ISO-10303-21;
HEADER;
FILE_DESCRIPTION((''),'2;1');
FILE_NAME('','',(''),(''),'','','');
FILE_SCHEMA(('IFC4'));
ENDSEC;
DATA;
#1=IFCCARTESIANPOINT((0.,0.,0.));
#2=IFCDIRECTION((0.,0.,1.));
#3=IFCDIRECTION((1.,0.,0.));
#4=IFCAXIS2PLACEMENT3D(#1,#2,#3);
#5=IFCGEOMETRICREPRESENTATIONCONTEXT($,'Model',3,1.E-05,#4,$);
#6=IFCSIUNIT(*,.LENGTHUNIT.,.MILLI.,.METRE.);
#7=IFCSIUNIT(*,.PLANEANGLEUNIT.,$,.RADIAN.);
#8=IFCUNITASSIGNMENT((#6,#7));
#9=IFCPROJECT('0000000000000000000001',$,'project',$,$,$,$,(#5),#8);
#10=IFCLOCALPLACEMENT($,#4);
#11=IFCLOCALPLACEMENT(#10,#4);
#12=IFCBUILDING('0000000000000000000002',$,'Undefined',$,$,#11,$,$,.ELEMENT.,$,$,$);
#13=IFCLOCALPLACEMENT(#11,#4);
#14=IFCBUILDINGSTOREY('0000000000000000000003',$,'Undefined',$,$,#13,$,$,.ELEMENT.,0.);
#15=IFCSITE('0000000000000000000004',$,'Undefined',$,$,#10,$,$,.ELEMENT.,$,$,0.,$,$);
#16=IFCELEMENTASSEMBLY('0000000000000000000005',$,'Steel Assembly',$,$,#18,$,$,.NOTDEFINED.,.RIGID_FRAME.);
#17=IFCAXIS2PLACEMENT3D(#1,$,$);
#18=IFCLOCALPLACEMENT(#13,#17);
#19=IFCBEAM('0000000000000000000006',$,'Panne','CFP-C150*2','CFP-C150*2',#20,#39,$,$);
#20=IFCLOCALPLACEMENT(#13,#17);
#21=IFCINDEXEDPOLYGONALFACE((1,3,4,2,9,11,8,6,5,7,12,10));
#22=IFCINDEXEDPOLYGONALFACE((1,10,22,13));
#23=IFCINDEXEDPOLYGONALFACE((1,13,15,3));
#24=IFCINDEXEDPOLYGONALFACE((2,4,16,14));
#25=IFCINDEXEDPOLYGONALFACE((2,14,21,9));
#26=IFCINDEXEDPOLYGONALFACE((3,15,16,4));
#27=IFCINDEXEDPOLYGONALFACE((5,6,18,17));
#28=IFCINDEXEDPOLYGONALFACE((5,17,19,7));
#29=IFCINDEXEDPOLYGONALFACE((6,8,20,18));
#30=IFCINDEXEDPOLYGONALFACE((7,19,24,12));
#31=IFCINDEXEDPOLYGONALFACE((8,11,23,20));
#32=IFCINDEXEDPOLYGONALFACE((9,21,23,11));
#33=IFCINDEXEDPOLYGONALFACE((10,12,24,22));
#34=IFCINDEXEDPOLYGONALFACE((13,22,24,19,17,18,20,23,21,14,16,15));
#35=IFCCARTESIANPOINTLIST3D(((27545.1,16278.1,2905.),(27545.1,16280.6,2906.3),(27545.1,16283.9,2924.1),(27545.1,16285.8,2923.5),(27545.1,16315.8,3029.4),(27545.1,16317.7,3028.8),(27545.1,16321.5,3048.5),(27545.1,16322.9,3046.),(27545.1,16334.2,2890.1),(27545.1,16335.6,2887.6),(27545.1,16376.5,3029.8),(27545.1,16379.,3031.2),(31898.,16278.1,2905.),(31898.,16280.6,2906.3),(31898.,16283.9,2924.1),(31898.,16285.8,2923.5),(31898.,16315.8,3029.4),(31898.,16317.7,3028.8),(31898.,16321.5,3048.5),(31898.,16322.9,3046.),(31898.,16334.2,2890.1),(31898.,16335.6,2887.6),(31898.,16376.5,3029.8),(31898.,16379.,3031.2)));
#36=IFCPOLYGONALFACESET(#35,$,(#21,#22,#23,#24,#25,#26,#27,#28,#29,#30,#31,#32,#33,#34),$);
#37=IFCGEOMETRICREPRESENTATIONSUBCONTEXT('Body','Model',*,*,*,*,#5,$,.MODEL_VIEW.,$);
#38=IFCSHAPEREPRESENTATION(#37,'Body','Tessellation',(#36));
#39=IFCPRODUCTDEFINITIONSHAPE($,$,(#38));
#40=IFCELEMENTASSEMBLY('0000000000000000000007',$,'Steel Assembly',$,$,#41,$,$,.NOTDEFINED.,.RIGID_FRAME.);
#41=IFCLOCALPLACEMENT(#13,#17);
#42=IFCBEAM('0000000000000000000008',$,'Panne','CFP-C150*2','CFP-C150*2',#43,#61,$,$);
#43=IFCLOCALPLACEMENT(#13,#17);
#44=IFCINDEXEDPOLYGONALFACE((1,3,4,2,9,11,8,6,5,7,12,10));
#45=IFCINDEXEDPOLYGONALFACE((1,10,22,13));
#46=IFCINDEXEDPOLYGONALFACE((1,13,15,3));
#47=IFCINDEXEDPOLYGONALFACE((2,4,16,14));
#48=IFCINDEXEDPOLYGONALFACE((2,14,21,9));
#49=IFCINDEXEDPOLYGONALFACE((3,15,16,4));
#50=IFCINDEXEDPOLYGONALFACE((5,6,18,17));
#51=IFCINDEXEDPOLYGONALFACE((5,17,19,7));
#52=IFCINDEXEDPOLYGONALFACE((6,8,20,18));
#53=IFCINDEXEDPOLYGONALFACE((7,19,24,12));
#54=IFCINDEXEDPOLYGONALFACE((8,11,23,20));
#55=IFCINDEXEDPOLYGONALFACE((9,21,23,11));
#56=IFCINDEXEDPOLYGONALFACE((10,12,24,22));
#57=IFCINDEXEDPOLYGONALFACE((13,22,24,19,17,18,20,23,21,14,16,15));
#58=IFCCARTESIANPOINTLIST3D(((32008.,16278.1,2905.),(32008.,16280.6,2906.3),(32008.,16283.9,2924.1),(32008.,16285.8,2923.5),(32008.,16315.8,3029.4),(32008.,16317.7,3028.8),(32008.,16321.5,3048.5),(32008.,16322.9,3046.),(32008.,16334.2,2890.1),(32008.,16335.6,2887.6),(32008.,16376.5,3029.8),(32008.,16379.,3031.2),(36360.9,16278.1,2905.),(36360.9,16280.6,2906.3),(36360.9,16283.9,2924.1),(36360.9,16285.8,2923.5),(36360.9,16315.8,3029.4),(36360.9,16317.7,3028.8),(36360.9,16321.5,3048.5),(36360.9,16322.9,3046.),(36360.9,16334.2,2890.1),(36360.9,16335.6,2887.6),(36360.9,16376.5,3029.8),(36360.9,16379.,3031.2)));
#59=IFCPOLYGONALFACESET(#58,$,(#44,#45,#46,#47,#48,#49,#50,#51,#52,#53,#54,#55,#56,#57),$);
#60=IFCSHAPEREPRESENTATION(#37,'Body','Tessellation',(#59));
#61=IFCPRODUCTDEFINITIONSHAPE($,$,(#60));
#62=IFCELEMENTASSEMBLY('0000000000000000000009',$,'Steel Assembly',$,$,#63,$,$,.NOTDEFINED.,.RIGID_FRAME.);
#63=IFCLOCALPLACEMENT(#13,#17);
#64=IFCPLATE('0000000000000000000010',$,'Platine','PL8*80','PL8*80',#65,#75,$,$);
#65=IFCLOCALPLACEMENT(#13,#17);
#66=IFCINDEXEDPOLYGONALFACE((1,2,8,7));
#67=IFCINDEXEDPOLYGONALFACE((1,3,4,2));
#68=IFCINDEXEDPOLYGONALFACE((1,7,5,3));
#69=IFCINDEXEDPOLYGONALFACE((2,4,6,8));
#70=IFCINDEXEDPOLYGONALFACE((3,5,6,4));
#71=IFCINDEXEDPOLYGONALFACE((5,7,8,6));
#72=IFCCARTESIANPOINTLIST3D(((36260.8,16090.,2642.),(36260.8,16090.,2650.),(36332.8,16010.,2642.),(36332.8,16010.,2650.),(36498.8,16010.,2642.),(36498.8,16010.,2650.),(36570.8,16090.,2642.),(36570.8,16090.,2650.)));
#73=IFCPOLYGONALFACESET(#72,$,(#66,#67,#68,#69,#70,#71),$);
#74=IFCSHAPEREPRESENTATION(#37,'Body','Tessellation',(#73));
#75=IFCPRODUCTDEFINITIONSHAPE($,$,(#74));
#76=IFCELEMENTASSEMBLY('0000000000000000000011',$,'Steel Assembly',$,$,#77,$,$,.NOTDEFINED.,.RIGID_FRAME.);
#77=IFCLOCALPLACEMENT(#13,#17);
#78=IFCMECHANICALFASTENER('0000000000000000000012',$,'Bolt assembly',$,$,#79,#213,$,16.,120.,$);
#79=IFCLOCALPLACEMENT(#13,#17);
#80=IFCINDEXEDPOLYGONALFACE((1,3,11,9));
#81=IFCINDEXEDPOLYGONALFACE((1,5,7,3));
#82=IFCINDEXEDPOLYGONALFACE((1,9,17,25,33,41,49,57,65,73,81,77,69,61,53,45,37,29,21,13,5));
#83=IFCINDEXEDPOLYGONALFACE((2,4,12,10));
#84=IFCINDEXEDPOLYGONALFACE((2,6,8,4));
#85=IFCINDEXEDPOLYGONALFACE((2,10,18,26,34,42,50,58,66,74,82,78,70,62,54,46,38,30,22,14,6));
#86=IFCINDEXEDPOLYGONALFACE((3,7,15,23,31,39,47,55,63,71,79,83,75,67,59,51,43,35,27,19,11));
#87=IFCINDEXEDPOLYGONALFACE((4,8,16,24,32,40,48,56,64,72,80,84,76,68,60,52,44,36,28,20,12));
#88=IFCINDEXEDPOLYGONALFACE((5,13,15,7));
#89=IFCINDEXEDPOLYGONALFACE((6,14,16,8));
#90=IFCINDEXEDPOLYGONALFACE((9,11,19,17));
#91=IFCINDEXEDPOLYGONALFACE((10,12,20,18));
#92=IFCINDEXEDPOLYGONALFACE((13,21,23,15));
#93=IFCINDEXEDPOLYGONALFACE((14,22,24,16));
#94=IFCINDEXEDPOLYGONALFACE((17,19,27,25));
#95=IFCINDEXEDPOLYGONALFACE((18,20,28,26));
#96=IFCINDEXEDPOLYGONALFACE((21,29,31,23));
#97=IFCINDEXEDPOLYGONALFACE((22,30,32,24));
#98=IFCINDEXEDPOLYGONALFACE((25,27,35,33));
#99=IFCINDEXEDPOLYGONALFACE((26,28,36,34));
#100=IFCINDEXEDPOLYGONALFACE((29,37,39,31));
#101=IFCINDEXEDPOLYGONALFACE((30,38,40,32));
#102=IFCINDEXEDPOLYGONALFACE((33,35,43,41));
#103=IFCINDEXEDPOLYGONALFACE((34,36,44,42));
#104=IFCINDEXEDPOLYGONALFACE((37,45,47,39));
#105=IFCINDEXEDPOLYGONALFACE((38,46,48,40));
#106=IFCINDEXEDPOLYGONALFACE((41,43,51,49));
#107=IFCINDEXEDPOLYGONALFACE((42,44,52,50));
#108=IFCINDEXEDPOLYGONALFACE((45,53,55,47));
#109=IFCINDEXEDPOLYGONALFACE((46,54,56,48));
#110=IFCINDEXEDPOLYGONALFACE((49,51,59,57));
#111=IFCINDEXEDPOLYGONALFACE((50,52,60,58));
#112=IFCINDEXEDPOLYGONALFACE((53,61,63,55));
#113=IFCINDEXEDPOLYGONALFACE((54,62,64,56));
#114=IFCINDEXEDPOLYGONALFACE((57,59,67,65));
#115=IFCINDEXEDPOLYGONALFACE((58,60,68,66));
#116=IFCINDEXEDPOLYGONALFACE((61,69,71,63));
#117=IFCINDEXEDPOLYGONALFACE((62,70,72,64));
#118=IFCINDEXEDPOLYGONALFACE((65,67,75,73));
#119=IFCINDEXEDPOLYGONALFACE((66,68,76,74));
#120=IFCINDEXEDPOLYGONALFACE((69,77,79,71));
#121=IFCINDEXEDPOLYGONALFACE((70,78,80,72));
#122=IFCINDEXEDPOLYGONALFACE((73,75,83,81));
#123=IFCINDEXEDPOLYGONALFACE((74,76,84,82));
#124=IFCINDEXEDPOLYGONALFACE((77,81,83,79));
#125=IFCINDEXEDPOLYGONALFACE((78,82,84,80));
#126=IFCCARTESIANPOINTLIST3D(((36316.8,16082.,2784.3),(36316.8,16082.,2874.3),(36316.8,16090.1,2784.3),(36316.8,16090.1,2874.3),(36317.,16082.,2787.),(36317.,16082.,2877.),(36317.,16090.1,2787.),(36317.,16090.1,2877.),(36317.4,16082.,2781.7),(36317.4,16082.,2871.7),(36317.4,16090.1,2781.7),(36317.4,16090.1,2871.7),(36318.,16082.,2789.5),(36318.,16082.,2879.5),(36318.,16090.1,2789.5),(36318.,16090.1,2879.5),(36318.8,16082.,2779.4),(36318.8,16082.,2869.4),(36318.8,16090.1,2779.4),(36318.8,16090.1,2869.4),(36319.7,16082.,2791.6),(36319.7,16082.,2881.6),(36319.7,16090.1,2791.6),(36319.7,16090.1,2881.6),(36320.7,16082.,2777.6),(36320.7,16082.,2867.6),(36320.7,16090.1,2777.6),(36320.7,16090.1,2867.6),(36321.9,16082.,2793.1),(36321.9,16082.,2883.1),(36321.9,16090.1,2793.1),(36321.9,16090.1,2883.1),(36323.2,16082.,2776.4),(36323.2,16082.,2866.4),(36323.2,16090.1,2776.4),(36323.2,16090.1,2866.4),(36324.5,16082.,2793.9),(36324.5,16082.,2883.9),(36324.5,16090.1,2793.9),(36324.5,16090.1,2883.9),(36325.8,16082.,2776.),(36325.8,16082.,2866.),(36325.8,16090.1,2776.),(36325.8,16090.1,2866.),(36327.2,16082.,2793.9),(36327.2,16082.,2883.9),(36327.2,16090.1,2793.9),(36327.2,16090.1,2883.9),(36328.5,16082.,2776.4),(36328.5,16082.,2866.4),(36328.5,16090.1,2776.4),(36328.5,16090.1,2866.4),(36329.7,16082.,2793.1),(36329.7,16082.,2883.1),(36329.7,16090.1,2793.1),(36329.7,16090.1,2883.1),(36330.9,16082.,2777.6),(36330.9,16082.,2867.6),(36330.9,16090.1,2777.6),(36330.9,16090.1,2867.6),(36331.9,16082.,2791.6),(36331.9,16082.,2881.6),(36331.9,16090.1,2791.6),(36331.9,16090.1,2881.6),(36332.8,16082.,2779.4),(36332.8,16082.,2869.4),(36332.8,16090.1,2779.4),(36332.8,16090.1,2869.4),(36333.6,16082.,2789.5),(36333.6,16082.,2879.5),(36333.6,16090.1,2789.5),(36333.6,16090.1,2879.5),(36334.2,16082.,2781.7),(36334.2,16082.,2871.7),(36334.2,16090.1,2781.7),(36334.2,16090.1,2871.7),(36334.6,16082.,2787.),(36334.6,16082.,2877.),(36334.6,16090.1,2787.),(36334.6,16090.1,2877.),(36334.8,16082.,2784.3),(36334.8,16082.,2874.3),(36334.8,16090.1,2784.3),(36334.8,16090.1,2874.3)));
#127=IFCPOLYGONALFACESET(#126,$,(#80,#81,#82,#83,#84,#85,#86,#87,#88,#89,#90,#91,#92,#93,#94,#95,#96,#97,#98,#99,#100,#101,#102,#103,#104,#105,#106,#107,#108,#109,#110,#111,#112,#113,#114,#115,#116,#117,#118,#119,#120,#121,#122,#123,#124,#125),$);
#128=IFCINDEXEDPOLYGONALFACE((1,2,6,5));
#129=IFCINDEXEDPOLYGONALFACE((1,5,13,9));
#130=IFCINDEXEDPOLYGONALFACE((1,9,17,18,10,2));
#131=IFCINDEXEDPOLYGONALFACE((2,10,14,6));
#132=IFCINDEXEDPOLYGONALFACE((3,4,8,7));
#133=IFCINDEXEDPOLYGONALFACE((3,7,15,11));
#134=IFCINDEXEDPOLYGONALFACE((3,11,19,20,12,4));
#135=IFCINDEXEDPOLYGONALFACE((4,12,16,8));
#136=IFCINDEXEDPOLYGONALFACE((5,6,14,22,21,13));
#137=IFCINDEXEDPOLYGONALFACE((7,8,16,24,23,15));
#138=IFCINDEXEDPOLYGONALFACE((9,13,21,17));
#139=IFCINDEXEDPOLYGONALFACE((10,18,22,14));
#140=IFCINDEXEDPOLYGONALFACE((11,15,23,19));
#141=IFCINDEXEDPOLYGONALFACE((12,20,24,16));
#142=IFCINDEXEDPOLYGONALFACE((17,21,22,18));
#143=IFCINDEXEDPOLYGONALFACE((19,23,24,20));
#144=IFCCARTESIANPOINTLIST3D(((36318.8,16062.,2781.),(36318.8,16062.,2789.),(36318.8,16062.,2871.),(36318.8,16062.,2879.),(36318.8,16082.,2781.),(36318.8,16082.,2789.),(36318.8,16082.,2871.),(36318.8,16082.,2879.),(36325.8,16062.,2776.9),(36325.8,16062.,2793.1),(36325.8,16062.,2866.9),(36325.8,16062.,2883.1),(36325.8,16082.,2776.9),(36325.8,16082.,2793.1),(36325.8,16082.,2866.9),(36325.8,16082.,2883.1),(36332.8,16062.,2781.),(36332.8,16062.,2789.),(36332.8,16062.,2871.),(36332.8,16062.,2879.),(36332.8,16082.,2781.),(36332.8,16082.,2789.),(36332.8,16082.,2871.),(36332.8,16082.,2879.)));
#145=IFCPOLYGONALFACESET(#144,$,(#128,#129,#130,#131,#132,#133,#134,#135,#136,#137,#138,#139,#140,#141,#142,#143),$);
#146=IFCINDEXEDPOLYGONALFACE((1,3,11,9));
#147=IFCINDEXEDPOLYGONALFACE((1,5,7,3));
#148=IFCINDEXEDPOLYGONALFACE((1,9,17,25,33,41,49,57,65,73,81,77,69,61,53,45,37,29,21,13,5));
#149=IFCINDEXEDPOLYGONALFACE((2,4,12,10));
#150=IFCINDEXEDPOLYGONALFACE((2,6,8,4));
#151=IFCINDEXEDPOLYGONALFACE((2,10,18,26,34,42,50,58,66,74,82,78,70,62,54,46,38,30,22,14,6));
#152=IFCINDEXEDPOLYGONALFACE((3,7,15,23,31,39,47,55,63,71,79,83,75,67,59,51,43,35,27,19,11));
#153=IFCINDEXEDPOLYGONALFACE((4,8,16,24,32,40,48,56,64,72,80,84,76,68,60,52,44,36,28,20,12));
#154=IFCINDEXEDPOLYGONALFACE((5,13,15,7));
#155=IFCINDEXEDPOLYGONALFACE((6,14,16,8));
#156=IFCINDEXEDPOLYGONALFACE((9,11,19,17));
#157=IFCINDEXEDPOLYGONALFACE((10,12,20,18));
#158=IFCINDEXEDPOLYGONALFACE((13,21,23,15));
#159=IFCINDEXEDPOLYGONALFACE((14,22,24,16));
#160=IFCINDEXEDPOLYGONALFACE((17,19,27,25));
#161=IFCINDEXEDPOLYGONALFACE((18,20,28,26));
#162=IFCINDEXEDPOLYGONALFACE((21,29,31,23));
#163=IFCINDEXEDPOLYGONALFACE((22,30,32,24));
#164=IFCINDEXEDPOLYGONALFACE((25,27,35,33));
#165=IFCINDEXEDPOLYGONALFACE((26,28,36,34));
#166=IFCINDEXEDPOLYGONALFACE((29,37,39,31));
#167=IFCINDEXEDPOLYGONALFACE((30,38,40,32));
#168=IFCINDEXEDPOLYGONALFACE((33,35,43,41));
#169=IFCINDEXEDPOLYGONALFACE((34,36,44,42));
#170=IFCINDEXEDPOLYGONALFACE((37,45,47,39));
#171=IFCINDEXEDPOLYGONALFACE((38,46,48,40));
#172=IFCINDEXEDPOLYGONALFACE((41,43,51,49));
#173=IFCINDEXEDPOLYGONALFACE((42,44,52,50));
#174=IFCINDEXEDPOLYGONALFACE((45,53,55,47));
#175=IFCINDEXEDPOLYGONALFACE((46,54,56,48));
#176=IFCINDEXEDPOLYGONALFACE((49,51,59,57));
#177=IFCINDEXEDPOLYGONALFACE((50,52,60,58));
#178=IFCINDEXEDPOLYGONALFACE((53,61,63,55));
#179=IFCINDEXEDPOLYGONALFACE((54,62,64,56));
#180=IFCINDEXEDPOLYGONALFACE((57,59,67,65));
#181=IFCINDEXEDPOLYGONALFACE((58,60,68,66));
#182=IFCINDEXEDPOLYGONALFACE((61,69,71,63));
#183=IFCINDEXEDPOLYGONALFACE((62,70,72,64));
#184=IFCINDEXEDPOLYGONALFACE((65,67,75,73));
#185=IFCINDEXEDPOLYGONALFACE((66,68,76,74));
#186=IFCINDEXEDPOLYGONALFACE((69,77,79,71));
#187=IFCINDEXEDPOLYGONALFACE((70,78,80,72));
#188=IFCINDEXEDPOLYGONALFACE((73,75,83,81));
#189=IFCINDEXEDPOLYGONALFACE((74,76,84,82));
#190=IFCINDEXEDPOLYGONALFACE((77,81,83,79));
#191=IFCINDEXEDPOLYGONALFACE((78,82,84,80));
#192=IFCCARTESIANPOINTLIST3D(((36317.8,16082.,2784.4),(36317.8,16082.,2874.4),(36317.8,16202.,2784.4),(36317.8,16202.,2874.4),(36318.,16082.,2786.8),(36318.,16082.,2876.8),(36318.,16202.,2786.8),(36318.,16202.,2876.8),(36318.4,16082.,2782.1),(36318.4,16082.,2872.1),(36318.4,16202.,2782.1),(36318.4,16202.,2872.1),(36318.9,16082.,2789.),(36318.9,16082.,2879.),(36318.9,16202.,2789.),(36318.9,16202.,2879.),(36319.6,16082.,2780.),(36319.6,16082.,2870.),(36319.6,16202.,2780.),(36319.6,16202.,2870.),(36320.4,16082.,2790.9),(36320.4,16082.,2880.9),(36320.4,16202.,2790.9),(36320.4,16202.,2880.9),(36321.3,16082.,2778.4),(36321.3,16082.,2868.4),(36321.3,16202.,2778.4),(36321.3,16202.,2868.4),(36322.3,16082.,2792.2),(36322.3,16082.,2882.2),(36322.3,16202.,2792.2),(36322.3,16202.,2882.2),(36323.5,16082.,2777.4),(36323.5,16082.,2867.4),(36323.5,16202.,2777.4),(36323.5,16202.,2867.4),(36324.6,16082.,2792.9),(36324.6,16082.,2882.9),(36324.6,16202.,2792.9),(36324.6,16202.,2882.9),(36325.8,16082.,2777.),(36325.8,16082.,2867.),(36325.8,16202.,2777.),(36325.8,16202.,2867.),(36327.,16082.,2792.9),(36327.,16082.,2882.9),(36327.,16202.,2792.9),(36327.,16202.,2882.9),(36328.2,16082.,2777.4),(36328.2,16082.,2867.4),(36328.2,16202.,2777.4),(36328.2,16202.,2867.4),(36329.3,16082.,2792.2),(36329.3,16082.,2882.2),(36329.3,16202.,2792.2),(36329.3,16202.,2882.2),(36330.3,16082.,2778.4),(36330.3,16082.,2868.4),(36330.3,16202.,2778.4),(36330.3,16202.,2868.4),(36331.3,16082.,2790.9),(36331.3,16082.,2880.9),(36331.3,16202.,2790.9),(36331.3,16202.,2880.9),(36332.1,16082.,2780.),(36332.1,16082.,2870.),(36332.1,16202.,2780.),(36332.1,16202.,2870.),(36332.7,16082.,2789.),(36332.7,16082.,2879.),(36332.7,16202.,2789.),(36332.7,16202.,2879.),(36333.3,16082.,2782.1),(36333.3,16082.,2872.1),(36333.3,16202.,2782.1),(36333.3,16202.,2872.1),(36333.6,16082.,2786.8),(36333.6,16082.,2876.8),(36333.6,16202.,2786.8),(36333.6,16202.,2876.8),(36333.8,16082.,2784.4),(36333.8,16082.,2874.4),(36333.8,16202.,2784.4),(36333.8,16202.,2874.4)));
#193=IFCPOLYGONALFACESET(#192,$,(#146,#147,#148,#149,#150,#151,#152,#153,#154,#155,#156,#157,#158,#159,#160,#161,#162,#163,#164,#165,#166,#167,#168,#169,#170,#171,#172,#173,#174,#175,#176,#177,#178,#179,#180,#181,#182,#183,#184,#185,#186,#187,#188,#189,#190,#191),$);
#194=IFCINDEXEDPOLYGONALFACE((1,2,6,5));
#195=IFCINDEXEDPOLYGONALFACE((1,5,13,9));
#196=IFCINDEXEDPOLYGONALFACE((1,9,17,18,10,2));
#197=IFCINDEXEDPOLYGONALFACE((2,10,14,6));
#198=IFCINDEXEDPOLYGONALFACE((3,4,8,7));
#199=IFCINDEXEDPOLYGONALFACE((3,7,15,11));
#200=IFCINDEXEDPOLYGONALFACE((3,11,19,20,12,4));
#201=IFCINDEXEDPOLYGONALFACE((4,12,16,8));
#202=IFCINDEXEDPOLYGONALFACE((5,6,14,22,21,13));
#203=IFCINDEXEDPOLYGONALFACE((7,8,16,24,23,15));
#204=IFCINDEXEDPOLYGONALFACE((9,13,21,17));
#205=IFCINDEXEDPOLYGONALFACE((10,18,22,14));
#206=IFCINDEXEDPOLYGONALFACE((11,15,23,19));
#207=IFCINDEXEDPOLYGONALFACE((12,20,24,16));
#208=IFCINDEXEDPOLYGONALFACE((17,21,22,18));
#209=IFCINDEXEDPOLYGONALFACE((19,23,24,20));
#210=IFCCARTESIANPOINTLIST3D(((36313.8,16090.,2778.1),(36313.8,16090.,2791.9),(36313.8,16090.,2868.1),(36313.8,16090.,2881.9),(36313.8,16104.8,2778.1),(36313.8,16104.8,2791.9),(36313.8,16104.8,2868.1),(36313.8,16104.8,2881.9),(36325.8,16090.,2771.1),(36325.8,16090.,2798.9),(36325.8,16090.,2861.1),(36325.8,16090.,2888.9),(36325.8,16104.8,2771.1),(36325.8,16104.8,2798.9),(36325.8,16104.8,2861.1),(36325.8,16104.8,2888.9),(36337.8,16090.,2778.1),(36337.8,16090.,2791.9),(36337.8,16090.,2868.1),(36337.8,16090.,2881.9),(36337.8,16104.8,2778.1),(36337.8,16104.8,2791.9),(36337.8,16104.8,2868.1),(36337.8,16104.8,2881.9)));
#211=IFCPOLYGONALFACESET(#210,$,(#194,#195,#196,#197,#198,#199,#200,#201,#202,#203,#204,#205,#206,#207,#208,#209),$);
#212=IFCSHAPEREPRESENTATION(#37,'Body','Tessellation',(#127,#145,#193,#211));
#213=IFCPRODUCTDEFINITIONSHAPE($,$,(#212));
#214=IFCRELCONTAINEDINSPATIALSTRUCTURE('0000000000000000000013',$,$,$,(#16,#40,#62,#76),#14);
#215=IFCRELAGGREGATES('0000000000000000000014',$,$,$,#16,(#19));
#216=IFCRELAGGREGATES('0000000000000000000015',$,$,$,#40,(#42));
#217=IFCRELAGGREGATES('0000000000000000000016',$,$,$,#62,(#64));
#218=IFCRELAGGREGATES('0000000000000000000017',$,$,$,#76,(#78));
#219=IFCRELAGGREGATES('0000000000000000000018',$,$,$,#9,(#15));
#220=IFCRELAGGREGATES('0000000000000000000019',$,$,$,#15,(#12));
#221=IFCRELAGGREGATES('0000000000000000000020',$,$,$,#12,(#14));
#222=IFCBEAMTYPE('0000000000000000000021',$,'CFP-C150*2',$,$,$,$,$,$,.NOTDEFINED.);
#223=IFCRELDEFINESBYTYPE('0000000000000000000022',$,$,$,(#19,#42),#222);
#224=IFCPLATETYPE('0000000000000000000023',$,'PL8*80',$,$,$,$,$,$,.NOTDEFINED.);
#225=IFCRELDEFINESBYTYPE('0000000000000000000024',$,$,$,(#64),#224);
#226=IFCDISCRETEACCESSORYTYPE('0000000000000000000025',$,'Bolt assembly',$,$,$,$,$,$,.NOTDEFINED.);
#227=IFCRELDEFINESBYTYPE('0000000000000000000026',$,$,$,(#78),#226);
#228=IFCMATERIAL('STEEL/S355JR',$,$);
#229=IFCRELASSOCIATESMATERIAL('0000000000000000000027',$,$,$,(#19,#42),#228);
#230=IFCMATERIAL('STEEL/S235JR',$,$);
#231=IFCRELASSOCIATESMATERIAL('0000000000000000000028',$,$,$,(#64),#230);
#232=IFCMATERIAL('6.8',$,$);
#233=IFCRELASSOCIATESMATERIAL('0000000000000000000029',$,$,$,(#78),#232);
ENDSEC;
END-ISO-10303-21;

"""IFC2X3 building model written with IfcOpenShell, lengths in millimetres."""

from ifc_helpers import new_model, si_unit, frame, origin_with_axes, origin_2d_with_axis, place, context, subcontext, project, spatial, polyline, circle, c_section, outline, extrude, source, transform, mapped, material, type_object, element, aggregate, save


model = new_model("IFC2X3")

# Units and contexts
model_context = context("Model", 3, precision=1e-05, world=origin_with_axes())
body_context = subcontext(model_context, "Body", "Model", "MODEL_VIEW")
ifc_project = project(units=[si_unit("LENGTHUNIT", "METRE", prefix="MILLI"), si_unit("PLANEANGLEUNIT", "RADIAN")], contexts=[model_context])

# Site, building, storey
site_placement = place(None, origin_with_axes())
site = spatial("IfcSite", under=ifc_project, at=site_placement, Name="Undefined", CompositionType="ELEMENT", RefElevation=0.0)
building_placement = place(site_placement, origin_with_axes())
building = spatial("IfcBuilding", under=site, at=building_placement, Name="Undefined", CompositionType="ELEMENT")
storey_placement = place(building_placement, origin_with_axes())
storey = spatial("IfcBuildingStorey", under=building, at=storey_placement, Name="Undefined", CompositionType="ELEMENT", Elevation=0.0)

# Element assemblies, beams
assembly_1_placement = place(storey_placement, origin_with_axes())
assembly_1 = element("IfcElementAssembly", 1, at=assembly_1_placement, inside=storey, Name="Steel Assembly", AssemblyPlace="NOTDEFINED", PredefinedType="RIGID_FRAME")
ifc_material_1 = material(Name="STEEL/S355JR")
beam_type = type_object("IfcBeamType", Name="CFP-C150*2", PredefinedType="NOTDEFINED")
beam_1_placement = place(assembly_1_placement, frame((31953.0, 16328.6, 2968.1), z_axis=(0.0, -0.289497, -0.957179), x_axis=(-1.0, 0.0, 0.0)))
beam_1 = element("IfcBeam", 2, at=beam_1_placement, type_object=beam_type, material=ifc_material_1, Name="Panne", Description="CFP-C150*2", ObjectType="CFP-C150*2", context=body_context, shape_type="SweptSolid", body=[
    extrude(c_section(Depth=150.0, Width=60.0, WallThickness=2.0, Girth=20.0, at=origin_2d_with_axis()), frame((4407.9, 0.0, 0.0), z_axis=(-1.0, 0.0, 0.0), x_axis=(0.0, -1.0, 0.0)), (0.0, 0.0, 1.0), 4352.9),
])
aggregate(assembly_1, [beam_1])
assembly_2_placement = place(storey_placement, origin_with_axes())
assembly_2 = element("IfcElementAssembly", 3, at=assembly_2_placement, inside=storey, Name="Steel Assembly", AssemblyPlace="NOTDEFINED", PredefinedType="RIGID_FRAME")
beam_2_placement = place(assembly_2_placement, frame((36415.8, 16328.6, 2968.1), z_axis=(0.0, -0.289497, -0.957179), x_axis=(-1.0, 0.0, 0.0)))
beam_2 = element("IfcBeam", 4, at=beam_2_placement, type_object=beam_type, material=ifc_material_1, Name="Panne", Description="CFP-C150*2", ObjectType="CFP-C150*2", context=body_context, shape_type="SweptSolid", body=[
    extrude(c_section(Depth=150.0, Width=60.0, WallThickness=2.0, Girth=20.0, at=origin_2d_with_axis()), frame((4407.9, 0.0, 0.0), z_axis=(-1.0, 0.0, 0.0), x_axis=(0.0, -1.0, 0.0)), (0.0, 0.0, 1.0), 4352.9),
])

# Element assembly, plate
assembly_3_placement = place(storey_placement, origin_with_axes())
assembly_3 = element("IfcElementAssembly", 5, at=assembly_3_placement, inside=storey, Name="Steel Assembly", AssemblyPlace="NOTDEFINED", PredefinedType="RIGID_FRAME")
ifc_material_2 = material(Name="STEEL/S235JR")
plate_type = type_object("IfcPlateType", Name="PL8*80", PredefinedType="NOTDEFINED")
plate_placement = place(assembly_3_placement, frame((36260.8, 16090.0, 2646.0), z_axis=(0.0, 0.0, 1.0), x_axis=(0.668965, -0.743294, 0.0)))
plate = element("IfcPlate", 6, at=plate_placement, type_object=plate_type, material=ifc_material_2, Name="Platine", Description="PL8*80", ObjectType="PL8*80", context=body_context, shape_type="SweptSolid", body=[
    extrude(outline(polyline([(0.0, 0.0), (107.6, 0.0), (218.7, 123.4), (207.4, 230.4), (0.0, 0.0)])), frame((0.0, 0.0, -4.0), z_axis=(0.0, 0.0, 1.0), x_axis=(1.0, 0.0, 0.0)), (0.0, 0.0, 1.0), 8.0),
])

# Element assembly, mechanical fastener
assembly_4_placement = place(storey_placement, origin_with_axes())
assembly_4 = element("IfcElementAssembly", 7, at=assembly_4_placement, inside=storey, Name="Steel Assembly", AssemblyPlace="NOTDEFINED", PredefinedType="RIGID_FRAME")
ifc_material_3 = material(Name="6.8")
discrete_accessory_type_1 = type_object("IfcDiscreteAccessoryType", Name="Bolt assembly")
shared_shape_1 = source(origin_with_axes(), body_context, "Body", "SweptSolid", [
    extrude(circle(Radius=9.0, at=origin_2d_with_axis()), frame((0.0, -8.0, 0.0), z_axis=(0.0, 1.0, 0.0), x_axis=(1.0, 0.0, 0.0)), (0.0, 0.0, 1.0), 8.1),
    extrude(outline(polyline([(8.1, 0.0), (4.0, 7.0), (-4.0, 7.0), (-8.1, 0.0), (-4.0, -7.0), (4.0, -7.0), (8.1, 0.0)])), frame((0.0, -28.0, 0.0), z_axis=(0.0, 1.0, 0.0), x_axis=(1.0, 0.0, 0.0)), (0.0, 0.0, 1.0), 20.0),
    extrude(circle(Radius=8.0, at=origin_2d_with_axis()), frame((0.0, -8.0, 0.0), z_axis=(0.0, 1.0, 0.0), x_axis=(1.0, 0.0, 0.0)), (0.0, 0.0, 1.0), 120.0),
    extrude(outline(polyline([(13.9, 0.0), (6.9, 12.0), (-6.9, 12.0), (-13.9, 0.0), (-6.9, -12.0), (6.9, -12.0), (13.9, 0.0)])), frame((0.0, 0.0, 0.0), z_axis=(0.0, 1.0, 0.0), x_axis=(1.0, 0.0, 0.0)), (0.0, 0.0, 1.0), 14.8),
])
mechanical_fastener_1_placement = place(assembly_4_placement, frame((36325.8, 16090.0, 2875.0), z_axis=(1.0, 0.0, 0.0), x_axis=(0.0, 0.0, -1.0)))
mechanical_fastener_1 = element("IfcMechanicalFastener", 8, at=mechanical_fastener_1_placement, type_object=discrete_accessory_type_1, material=ifc_material_3, Name="Bolt assembly", NominalDiameter=16.0, NominalLength=120.0, context=body_context, shape_type="MappedRepresentation", body=[
    mapped(shared_shape_1, transform((0.0, 0.0, 0.0))),
    mapped(shared_shape_1, transform((90.0, 0.0, 0.0))),
])

aggregate(assembly_2, [beam_2])

aggregate(assembly_3, [plate])
aggregate(assembly_4, [mechanical_fastener_1])

save(model, "model.ifc")
